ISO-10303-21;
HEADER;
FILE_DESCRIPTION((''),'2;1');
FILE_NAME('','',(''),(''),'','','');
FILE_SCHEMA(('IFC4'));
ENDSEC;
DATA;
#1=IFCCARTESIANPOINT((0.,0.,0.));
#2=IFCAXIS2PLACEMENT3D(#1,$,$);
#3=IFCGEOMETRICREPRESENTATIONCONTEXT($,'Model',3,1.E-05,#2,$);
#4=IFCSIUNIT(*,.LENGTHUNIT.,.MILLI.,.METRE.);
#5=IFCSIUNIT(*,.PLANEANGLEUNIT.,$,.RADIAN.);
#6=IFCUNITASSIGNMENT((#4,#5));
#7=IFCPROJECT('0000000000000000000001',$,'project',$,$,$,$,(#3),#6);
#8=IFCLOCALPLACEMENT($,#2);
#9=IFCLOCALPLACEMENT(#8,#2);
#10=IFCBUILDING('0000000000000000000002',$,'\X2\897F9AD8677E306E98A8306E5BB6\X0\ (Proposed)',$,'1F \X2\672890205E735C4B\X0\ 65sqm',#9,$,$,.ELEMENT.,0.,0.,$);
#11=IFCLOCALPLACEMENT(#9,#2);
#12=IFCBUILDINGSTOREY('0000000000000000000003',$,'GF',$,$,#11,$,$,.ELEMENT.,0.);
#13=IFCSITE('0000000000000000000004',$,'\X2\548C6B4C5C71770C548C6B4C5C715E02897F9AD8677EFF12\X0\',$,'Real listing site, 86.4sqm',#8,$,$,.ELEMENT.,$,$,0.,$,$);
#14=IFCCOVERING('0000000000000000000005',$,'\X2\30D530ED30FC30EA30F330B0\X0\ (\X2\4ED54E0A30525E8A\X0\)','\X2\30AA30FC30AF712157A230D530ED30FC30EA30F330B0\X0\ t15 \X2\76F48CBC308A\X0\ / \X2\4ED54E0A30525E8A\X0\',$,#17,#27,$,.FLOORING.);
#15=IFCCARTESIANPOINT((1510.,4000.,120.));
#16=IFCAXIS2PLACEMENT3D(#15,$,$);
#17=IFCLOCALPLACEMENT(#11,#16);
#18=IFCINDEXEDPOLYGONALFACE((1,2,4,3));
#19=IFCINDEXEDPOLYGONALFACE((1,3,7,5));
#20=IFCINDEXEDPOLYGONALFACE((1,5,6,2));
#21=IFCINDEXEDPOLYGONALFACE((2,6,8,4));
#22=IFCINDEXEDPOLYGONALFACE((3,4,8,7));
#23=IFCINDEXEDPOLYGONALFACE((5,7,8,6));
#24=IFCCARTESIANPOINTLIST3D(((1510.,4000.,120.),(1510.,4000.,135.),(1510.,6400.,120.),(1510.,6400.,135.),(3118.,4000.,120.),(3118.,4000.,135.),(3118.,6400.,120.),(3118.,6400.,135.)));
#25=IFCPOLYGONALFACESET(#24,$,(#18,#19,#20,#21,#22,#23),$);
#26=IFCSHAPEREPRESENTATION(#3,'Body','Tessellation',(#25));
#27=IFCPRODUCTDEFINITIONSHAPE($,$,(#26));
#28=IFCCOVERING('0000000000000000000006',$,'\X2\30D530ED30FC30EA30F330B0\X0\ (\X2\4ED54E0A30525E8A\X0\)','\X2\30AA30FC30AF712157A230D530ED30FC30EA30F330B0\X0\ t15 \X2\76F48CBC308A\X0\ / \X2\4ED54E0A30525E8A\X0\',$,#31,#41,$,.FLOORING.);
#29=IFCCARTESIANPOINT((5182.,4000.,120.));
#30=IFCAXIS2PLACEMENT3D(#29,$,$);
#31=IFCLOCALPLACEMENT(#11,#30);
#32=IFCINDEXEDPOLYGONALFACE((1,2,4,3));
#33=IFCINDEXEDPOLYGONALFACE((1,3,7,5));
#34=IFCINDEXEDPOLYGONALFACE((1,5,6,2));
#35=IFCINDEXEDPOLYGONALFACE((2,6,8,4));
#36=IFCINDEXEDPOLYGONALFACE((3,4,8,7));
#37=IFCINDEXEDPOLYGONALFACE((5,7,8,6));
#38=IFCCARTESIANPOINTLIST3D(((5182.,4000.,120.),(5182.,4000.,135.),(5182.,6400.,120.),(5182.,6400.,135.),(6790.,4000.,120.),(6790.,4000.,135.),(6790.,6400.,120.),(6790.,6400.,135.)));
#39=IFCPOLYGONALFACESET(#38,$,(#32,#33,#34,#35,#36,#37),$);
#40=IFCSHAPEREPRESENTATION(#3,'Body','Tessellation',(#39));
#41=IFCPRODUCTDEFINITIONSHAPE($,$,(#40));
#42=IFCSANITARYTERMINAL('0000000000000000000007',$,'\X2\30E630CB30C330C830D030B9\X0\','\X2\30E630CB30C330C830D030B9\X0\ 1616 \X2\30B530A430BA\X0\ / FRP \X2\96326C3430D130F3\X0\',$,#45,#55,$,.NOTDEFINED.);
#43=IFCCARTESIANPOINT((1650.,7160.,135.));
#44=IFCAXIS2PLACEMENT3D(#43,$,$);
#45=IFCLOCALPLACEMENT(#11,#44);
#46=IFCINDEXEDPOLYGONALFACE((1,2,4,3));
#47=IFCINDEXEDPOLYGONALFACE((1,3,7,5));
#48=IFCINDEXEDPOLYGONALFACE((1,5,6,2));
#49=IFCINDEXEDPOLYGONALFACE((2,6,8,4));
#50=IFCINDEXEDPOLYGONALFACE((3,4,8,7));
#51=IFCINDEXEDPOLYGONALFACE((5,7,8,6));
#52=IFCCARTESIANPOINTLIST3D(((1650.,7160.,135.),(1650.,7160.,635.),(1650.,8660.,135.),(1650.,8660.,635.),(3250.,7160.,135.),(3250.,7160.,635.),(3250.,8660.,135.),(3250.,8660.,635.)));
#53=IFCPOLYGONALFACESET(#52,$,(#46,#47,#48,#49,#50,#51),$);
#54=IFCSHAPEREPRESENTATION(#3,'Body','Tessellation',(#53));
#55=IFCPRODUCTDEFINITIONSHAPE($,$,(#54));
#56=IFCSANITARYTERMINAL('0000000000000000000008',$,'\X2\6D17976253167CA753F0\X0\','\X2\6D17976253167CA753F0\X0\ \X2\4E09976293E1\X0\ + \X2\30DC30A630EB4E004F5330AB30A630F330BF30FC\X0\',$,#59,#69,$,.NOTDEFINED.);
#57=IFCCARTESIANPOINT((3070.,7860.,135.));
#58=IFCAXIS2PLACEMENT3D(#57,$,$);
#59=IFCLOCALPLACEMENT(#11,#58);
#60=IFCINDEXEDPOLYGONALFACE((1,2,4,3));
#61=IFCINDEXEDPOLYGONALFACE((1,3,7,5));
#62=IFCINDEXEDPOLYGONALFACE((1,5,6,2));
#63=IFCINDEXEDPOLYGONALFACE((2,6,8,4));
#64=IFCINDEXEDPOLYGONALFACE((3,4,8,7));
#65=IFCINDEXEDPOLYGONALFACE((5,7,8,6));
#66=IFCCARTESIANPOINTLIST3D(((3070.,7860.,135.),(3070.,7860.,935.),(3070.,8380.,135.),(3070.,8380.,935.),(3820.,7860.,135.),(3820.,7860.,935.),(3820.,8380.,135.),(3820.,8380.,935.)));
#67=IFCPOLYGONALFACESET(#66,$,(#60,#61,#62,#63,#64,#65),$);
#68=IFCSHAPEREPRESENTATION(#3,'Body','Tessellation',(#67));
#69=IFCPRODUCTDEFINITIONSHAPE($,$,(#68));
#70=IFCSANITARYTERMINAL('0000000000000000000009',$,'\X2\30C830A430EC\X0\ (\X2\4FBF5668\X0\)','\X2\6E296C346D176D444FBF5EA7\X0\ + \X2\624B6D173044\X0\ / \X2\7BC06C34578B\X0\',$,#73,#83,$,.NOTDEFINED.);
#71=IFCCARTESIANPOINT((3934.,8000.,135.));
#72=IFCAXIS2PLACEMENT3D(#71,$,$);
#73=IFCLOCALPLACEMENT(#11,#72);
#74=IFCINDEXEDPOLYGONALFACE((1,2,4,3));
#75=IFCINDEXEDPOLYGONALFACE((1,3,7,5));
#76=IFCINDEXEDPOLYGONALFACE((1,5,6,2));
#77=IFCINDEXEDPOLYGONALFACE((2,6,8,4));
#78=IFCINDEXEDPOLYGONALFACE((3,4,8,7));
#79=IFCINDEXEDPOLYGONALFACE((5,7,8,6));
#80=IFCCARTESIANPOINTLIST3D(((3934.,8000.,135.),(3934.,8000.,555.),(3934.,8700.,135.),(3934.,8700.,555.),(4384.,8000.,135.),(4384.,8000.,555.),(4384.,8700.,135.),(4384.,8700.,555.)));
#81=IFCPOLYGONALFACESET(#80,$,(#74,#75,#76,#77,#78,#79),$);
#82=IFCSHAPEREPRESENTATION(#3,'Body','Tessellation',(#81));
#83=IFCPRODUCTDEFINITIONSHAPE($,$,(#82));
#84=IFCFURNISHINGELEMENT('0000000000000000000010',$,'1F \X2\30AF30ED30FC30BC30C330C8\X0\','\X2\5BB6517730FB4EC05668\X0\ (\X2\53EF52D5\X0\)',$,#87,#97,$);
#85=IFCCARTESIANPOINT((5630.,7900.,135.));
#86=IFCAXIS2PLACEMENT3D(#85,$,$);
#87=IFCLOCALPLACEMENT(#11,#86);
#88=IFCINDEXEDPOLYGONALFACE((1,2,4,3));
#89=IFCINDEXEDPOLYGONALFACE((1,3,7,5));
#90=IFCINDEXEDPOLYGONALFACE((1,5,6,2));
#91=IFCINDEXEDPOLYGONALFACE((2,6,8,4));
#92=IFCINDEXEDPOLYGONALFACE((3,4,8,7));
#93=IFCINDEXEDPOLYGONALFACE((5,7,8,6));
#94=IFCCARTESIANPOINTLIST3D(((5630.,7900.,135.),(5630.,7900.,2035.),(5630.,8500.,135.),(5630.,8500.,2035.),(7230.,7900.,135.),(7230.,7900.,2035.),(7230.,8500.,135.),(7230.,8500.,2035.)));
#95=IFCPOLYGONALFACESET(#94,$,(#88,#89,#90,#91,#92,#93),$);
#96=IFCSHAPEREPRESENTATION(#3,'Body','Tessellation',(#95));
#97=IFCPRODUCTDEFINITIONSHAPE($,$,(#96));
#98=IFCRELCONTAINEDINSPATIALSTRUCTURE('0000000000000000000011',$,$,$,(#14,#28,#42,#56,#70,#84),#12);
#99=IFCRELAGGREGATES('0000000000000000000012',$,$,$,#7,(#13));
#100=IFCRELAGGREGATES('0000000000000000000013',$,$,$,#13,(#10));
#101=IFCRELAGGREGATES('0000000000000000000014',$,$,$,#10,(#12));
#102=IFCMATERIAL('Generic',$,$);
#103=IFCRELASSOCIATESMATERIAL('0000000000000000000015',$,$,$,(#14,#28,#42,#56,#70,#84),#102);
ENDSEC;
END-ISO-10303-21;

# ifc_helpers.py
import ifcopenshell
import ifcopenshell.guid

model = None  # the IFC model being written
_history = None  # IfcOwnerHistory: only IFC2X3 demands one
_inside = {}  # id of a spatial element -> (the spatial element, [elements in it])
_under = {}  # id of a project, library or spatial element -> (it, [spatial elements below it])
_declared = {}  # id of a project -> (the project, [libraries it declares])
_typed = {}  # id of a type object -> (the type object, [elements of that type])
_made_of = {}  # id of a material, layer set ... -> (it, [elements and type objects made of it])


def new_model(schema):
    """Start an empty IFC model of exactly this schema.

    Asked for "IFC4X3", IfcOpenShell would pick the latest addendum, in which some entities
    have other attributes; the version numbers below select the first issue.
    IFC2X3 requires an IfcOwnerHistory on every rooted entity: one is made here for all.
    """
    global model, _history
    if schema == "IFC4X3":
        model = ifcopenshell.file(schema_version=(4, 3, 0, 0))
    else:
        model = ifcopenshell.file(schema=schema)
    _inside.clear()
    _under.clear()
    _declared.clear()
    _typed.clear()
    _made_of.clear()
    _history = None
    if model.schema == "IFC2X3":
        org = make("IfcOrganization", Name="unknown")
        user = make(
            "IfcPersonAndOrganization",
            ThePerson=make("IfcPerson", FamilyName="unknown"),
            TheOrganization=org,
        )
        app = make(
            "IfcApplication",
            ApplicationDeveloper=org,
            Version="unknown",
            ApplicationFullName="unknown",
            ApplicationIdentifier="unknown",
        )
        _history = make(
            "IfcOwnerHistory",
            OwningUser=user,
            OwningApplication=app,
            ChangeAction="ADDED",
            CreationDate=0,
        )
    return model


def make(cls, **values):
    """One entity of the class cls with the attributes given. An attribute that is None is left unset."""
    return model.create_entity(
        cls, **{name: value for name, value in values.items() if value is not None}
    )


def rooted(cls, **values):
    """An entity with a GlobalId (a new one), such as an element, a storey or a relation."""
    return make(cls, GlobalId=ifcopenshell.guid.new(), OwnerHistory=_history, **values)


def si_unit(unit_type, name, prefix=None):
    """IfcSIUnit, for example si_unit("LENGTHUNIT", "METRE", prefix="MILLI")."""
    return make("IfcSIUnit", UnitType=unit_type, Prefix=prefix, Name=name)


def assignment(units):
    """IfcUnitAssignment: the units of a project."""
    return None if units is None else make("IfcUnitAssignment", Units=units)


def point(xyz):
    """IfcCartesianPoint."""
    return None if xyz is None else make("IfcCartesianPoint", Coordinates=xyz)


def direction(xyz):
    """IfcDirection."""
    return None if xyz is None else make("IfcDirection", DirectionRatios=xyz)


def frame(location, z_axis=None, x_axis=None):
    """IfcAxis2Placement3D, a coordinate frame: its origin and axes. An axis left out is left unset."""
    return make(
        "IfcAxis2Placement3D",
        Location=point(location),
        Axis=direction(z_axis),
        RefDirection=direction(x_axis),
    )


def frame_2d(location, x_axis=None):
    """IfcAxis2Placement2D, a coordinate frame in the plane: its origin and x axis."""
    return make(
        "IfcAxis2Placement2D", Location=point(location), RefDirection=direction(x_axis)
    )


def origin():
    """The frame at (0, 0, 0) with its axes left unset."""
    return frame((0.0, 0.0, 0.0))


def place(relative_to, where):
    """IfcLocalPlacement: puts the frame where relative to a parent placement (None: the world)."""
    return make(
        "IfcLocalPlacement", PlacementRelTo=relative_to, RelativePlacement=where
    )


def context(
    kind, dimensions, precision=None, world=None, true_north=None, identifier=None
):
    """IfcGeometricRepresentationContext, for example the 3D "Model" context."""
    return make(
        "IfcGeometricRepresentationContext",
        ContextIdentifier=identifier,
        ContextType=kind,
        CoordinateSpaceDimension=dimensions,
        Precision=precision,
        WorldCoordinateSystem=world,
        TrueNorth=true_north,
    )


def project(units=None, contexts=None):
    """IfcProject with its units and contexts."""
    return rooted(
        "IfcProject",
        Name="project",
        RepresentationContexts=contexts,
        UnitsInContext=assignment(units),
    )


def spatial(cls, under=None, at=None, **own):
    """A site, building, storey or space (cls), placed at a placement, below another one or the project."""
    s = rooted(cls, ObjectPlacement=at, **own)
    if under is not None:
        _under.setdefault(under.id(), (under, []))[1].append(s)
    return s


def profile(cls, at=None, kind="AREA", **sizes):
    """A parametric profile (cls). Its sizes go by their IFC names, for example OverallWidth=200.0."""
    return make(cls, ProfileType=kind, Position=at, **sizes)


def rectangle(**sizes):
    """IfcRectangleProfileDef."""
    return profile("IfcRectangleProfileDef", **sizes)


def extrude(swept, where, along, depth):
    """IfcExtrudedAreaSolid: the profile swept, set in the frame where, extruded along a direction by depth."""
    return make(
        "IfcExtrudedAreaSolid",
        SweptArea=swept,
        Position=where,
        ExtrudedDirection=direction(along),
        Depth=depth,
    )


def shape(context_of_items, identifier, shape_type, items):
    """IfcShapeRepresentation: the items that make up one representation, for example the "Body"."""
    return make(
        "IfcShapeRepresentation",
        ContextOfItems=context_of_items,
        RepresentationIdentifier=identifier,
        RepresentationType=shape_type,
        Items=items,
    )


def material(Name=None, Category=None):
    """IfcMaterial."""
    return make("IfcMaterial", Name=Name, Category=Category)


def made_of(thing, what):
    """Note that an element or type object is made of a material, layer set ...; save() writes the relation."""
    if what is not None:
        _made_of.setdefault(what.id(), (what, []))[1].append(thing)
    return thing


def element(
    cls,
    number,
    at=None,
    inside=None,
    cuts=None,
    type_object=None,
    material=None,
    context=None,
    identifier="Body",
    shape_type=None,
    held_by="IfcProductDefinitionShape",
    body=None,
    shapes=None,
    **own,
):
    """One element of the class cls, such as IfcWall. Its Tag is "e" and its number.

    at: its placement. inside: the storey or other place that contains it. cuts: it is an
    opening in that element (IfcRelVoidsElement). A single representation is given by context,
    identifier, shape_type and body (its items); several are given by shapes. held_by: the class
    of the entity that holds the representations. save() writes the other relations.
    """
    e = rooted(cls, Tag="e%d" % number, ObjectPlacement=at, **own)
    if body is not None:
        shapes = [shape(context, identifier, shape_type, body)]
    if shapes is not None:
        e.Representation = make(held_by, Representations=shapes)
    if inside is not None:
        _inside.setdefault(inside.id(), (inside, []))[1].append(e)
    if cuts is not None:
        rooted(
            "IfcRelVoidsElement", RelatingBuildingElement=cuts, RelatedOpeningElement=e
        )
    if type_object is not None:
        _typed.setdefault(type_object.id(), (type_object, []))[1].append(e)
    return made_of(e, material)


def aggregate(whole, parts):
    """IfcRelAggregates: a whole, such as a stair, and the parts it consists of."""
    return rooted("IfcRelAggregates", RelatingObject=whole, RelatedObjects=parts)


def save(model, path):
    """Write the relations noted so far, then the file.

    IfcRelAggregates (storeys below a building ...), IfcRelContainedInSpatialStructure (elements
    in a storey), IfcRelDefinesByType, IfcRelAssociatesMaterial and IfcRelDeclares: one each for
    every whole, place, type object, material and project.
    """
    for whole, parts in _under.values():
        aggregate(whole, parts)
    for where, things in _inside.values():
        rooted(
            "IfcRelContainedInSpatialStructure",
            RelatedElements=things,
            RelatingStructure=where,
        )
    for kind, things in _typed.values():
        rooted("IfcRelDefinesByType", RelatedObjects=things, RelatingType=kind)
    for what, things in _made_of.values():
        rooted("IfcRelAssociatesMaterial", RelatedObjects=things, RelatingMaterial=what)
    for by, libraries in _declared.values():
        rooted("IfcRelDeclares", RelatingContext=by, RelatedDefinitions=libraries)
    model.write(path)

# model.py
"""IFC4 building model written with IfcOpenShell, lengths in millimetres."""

from ifc_helpers import new_model, si_unit, frame, frame_2d, origin, place, context, project, spatial, rectangle, extrude, material, element, save


model = new_model("IFC4")

# Units and contexts
model_context = context("Model", 3, precision=1e-05, world=origin())
ifc_project = project(units=[si_unit("LENGTHUNIT", "METRE", prefix="MILLI"), si_unit("PLANEANGLEUNIT", "RADIAN")], contexts=[model_context])

# Site, building, storey
site_placement = place(None, origin())
site = spatial("IfcSite", under=ifc_project, at=site_placement, Name="和歌山県和歌山市西高松２", ObjectType="Real listing site, 86.4sqm", CompositionType="ELEMENT", RefElevation=0.0)
building_placement = place(site_placement, origin())
building = spatial("IfcBuilding", under=site, at=building_placement, Name="西高松の風の家 (Proposed)", ObjectType="1F 木造平屋 65sqm", CompositionType="ELEMENT", ElevationOfRefHeight=0.0, ElevationOfTerrain=0.0)
storey_placement = place(building_placement, origin())
storey = spatial("IfcBuildingStorey", under=building, at=storey_placement, Name="GF", CompositionType="ELEMENT", Elevation=0.0)

# Coverings
ifc_material_1 = material(Name="Generic")
covering_1_placement = place(storey_placement, frame((1510.0, 4000.0, 120.0)))
element("IfcCovering", 1, at=covering_1_placement, inside=storey, material=ifc_material_1, Name="フローリング (仕上げ床)", Description="オーク無垢フローリング t15 直貼り / 仕上げ床", PredefinedType="FLOORING", context=model_context, shape_type="SweptSolid", body=[
    extrude(rectangle(XDim=1608.0, YDim=2400.0, at=frame_2d((804.0, 1200.0))), frame((1510.0, 4000.0, 120.0)), (0.0, 0.0, 1.0), 15.0),
])
covering_2_placement = place(storey_placement, frame((5182.0, 4000.0, 120.0)))
element("IfcCovering", 2, at=covering_2_placement, inside=storey, material=ifc_material_1, Name="フローリング (仕上げ床)", Description="オーク無垢フローリング t15 直貼り / 仕上げ床", PredefinedType="FLOORING", context=model_context, shape_type="SweptSolid", body=[
    extrude(rectangle(XDim=1608.0, YDim=2400.0, at=frame_2d((804.0, 1200.0))), frame((5182.0, 4000.0, 120.0)), (0.0, 0.0, 1.0), 15.0),
])

# Sanitary terminals
sanitary_terminal_1_placement = place(storey_placement, frame((1650.0, 7160.0, 135.0)))
element("IfcSanitaryTerminal", 3, at=sanitary_terminal_1_placement, inside=storey, material=ifc_material_1, Name="ユニットバス", Description="ユニットバス 1616 サイズ / FRP 防水パン", PredefinedType="NOTDEFINED", context=model_context, shape_type="SweptSolid", body=[
    extrude(rectangle(XDim=1600.0, YDim=1500.0, at=frame_2d((800.0, 750.0))), frame((1650.0, 7160.0, 135.0)), (0.0, 0.0, 1.0), 500.0),
])
sanitary_terminal_2_placement = place(storey_placement, frame((3070.0, 7860.0, 135.0)))
element("IfcSanitaryTerminal", 4, at=sanitary_terminal_2_placement, inside=storey, material=ifc_material_1, Name="洗面化粧台", Description="洗面化粧台 三面鏡 + ボウル一体カウンター", PredefinedType="NOTDEFINED", context=model_context, shape_type="SweptSolid", body=[
    extrude(rectangle(XDim=750.0, YDim=520.0, at=frame_2d((375.0, 260.0))), frame((3070.0, 7860.0, 135.0)), (0.0, 0.0, 1.0), 800.0),
])
sanitary_terminal_3_placement = place(storey_placement, frame((3934.0, 8000.0, 135.0)))
element("IfcSanitaryTerminal", 5, at=sanitary_terminal_3_placement, inside=storey, material=ifc_material_1, Name="トイレ (便器)", Description="温水洗浄便座 + 手洗い / 節水型", PredefinedType="NOTDEFINED", context=model_context, shape_type="SweptSolid", body=[
    extrude(rectangle(XDim=450.0, YDim=700.0, at=frame_2d((225.0, 350.0))), frame((3934.0, 8000.0, 135.0)), (0.0, 0.0, 1.0), 420.0),
])

# Furnishing element
furnishing_placement = place(storey_placement, frame((5630.0, 7900.0, 135.0)))
element("IfcFurnishingElement", 6, at=furnishing_placement, inside=storey, material=ifc_material_1, Name="1F クローゼット", Description="家具・什器 (可動)", context=model_context, shape_type="SweptSolid", body=[
    extrude(rectangle(XDim=1600.0, YDim=600.0, at=frame_2d((800.0, 300.0))), frame((5630.0, 7900.0, 135.0)), (0.0, 0.0, 1.0), 1900.0),
])

save(model, "model.ifc")
